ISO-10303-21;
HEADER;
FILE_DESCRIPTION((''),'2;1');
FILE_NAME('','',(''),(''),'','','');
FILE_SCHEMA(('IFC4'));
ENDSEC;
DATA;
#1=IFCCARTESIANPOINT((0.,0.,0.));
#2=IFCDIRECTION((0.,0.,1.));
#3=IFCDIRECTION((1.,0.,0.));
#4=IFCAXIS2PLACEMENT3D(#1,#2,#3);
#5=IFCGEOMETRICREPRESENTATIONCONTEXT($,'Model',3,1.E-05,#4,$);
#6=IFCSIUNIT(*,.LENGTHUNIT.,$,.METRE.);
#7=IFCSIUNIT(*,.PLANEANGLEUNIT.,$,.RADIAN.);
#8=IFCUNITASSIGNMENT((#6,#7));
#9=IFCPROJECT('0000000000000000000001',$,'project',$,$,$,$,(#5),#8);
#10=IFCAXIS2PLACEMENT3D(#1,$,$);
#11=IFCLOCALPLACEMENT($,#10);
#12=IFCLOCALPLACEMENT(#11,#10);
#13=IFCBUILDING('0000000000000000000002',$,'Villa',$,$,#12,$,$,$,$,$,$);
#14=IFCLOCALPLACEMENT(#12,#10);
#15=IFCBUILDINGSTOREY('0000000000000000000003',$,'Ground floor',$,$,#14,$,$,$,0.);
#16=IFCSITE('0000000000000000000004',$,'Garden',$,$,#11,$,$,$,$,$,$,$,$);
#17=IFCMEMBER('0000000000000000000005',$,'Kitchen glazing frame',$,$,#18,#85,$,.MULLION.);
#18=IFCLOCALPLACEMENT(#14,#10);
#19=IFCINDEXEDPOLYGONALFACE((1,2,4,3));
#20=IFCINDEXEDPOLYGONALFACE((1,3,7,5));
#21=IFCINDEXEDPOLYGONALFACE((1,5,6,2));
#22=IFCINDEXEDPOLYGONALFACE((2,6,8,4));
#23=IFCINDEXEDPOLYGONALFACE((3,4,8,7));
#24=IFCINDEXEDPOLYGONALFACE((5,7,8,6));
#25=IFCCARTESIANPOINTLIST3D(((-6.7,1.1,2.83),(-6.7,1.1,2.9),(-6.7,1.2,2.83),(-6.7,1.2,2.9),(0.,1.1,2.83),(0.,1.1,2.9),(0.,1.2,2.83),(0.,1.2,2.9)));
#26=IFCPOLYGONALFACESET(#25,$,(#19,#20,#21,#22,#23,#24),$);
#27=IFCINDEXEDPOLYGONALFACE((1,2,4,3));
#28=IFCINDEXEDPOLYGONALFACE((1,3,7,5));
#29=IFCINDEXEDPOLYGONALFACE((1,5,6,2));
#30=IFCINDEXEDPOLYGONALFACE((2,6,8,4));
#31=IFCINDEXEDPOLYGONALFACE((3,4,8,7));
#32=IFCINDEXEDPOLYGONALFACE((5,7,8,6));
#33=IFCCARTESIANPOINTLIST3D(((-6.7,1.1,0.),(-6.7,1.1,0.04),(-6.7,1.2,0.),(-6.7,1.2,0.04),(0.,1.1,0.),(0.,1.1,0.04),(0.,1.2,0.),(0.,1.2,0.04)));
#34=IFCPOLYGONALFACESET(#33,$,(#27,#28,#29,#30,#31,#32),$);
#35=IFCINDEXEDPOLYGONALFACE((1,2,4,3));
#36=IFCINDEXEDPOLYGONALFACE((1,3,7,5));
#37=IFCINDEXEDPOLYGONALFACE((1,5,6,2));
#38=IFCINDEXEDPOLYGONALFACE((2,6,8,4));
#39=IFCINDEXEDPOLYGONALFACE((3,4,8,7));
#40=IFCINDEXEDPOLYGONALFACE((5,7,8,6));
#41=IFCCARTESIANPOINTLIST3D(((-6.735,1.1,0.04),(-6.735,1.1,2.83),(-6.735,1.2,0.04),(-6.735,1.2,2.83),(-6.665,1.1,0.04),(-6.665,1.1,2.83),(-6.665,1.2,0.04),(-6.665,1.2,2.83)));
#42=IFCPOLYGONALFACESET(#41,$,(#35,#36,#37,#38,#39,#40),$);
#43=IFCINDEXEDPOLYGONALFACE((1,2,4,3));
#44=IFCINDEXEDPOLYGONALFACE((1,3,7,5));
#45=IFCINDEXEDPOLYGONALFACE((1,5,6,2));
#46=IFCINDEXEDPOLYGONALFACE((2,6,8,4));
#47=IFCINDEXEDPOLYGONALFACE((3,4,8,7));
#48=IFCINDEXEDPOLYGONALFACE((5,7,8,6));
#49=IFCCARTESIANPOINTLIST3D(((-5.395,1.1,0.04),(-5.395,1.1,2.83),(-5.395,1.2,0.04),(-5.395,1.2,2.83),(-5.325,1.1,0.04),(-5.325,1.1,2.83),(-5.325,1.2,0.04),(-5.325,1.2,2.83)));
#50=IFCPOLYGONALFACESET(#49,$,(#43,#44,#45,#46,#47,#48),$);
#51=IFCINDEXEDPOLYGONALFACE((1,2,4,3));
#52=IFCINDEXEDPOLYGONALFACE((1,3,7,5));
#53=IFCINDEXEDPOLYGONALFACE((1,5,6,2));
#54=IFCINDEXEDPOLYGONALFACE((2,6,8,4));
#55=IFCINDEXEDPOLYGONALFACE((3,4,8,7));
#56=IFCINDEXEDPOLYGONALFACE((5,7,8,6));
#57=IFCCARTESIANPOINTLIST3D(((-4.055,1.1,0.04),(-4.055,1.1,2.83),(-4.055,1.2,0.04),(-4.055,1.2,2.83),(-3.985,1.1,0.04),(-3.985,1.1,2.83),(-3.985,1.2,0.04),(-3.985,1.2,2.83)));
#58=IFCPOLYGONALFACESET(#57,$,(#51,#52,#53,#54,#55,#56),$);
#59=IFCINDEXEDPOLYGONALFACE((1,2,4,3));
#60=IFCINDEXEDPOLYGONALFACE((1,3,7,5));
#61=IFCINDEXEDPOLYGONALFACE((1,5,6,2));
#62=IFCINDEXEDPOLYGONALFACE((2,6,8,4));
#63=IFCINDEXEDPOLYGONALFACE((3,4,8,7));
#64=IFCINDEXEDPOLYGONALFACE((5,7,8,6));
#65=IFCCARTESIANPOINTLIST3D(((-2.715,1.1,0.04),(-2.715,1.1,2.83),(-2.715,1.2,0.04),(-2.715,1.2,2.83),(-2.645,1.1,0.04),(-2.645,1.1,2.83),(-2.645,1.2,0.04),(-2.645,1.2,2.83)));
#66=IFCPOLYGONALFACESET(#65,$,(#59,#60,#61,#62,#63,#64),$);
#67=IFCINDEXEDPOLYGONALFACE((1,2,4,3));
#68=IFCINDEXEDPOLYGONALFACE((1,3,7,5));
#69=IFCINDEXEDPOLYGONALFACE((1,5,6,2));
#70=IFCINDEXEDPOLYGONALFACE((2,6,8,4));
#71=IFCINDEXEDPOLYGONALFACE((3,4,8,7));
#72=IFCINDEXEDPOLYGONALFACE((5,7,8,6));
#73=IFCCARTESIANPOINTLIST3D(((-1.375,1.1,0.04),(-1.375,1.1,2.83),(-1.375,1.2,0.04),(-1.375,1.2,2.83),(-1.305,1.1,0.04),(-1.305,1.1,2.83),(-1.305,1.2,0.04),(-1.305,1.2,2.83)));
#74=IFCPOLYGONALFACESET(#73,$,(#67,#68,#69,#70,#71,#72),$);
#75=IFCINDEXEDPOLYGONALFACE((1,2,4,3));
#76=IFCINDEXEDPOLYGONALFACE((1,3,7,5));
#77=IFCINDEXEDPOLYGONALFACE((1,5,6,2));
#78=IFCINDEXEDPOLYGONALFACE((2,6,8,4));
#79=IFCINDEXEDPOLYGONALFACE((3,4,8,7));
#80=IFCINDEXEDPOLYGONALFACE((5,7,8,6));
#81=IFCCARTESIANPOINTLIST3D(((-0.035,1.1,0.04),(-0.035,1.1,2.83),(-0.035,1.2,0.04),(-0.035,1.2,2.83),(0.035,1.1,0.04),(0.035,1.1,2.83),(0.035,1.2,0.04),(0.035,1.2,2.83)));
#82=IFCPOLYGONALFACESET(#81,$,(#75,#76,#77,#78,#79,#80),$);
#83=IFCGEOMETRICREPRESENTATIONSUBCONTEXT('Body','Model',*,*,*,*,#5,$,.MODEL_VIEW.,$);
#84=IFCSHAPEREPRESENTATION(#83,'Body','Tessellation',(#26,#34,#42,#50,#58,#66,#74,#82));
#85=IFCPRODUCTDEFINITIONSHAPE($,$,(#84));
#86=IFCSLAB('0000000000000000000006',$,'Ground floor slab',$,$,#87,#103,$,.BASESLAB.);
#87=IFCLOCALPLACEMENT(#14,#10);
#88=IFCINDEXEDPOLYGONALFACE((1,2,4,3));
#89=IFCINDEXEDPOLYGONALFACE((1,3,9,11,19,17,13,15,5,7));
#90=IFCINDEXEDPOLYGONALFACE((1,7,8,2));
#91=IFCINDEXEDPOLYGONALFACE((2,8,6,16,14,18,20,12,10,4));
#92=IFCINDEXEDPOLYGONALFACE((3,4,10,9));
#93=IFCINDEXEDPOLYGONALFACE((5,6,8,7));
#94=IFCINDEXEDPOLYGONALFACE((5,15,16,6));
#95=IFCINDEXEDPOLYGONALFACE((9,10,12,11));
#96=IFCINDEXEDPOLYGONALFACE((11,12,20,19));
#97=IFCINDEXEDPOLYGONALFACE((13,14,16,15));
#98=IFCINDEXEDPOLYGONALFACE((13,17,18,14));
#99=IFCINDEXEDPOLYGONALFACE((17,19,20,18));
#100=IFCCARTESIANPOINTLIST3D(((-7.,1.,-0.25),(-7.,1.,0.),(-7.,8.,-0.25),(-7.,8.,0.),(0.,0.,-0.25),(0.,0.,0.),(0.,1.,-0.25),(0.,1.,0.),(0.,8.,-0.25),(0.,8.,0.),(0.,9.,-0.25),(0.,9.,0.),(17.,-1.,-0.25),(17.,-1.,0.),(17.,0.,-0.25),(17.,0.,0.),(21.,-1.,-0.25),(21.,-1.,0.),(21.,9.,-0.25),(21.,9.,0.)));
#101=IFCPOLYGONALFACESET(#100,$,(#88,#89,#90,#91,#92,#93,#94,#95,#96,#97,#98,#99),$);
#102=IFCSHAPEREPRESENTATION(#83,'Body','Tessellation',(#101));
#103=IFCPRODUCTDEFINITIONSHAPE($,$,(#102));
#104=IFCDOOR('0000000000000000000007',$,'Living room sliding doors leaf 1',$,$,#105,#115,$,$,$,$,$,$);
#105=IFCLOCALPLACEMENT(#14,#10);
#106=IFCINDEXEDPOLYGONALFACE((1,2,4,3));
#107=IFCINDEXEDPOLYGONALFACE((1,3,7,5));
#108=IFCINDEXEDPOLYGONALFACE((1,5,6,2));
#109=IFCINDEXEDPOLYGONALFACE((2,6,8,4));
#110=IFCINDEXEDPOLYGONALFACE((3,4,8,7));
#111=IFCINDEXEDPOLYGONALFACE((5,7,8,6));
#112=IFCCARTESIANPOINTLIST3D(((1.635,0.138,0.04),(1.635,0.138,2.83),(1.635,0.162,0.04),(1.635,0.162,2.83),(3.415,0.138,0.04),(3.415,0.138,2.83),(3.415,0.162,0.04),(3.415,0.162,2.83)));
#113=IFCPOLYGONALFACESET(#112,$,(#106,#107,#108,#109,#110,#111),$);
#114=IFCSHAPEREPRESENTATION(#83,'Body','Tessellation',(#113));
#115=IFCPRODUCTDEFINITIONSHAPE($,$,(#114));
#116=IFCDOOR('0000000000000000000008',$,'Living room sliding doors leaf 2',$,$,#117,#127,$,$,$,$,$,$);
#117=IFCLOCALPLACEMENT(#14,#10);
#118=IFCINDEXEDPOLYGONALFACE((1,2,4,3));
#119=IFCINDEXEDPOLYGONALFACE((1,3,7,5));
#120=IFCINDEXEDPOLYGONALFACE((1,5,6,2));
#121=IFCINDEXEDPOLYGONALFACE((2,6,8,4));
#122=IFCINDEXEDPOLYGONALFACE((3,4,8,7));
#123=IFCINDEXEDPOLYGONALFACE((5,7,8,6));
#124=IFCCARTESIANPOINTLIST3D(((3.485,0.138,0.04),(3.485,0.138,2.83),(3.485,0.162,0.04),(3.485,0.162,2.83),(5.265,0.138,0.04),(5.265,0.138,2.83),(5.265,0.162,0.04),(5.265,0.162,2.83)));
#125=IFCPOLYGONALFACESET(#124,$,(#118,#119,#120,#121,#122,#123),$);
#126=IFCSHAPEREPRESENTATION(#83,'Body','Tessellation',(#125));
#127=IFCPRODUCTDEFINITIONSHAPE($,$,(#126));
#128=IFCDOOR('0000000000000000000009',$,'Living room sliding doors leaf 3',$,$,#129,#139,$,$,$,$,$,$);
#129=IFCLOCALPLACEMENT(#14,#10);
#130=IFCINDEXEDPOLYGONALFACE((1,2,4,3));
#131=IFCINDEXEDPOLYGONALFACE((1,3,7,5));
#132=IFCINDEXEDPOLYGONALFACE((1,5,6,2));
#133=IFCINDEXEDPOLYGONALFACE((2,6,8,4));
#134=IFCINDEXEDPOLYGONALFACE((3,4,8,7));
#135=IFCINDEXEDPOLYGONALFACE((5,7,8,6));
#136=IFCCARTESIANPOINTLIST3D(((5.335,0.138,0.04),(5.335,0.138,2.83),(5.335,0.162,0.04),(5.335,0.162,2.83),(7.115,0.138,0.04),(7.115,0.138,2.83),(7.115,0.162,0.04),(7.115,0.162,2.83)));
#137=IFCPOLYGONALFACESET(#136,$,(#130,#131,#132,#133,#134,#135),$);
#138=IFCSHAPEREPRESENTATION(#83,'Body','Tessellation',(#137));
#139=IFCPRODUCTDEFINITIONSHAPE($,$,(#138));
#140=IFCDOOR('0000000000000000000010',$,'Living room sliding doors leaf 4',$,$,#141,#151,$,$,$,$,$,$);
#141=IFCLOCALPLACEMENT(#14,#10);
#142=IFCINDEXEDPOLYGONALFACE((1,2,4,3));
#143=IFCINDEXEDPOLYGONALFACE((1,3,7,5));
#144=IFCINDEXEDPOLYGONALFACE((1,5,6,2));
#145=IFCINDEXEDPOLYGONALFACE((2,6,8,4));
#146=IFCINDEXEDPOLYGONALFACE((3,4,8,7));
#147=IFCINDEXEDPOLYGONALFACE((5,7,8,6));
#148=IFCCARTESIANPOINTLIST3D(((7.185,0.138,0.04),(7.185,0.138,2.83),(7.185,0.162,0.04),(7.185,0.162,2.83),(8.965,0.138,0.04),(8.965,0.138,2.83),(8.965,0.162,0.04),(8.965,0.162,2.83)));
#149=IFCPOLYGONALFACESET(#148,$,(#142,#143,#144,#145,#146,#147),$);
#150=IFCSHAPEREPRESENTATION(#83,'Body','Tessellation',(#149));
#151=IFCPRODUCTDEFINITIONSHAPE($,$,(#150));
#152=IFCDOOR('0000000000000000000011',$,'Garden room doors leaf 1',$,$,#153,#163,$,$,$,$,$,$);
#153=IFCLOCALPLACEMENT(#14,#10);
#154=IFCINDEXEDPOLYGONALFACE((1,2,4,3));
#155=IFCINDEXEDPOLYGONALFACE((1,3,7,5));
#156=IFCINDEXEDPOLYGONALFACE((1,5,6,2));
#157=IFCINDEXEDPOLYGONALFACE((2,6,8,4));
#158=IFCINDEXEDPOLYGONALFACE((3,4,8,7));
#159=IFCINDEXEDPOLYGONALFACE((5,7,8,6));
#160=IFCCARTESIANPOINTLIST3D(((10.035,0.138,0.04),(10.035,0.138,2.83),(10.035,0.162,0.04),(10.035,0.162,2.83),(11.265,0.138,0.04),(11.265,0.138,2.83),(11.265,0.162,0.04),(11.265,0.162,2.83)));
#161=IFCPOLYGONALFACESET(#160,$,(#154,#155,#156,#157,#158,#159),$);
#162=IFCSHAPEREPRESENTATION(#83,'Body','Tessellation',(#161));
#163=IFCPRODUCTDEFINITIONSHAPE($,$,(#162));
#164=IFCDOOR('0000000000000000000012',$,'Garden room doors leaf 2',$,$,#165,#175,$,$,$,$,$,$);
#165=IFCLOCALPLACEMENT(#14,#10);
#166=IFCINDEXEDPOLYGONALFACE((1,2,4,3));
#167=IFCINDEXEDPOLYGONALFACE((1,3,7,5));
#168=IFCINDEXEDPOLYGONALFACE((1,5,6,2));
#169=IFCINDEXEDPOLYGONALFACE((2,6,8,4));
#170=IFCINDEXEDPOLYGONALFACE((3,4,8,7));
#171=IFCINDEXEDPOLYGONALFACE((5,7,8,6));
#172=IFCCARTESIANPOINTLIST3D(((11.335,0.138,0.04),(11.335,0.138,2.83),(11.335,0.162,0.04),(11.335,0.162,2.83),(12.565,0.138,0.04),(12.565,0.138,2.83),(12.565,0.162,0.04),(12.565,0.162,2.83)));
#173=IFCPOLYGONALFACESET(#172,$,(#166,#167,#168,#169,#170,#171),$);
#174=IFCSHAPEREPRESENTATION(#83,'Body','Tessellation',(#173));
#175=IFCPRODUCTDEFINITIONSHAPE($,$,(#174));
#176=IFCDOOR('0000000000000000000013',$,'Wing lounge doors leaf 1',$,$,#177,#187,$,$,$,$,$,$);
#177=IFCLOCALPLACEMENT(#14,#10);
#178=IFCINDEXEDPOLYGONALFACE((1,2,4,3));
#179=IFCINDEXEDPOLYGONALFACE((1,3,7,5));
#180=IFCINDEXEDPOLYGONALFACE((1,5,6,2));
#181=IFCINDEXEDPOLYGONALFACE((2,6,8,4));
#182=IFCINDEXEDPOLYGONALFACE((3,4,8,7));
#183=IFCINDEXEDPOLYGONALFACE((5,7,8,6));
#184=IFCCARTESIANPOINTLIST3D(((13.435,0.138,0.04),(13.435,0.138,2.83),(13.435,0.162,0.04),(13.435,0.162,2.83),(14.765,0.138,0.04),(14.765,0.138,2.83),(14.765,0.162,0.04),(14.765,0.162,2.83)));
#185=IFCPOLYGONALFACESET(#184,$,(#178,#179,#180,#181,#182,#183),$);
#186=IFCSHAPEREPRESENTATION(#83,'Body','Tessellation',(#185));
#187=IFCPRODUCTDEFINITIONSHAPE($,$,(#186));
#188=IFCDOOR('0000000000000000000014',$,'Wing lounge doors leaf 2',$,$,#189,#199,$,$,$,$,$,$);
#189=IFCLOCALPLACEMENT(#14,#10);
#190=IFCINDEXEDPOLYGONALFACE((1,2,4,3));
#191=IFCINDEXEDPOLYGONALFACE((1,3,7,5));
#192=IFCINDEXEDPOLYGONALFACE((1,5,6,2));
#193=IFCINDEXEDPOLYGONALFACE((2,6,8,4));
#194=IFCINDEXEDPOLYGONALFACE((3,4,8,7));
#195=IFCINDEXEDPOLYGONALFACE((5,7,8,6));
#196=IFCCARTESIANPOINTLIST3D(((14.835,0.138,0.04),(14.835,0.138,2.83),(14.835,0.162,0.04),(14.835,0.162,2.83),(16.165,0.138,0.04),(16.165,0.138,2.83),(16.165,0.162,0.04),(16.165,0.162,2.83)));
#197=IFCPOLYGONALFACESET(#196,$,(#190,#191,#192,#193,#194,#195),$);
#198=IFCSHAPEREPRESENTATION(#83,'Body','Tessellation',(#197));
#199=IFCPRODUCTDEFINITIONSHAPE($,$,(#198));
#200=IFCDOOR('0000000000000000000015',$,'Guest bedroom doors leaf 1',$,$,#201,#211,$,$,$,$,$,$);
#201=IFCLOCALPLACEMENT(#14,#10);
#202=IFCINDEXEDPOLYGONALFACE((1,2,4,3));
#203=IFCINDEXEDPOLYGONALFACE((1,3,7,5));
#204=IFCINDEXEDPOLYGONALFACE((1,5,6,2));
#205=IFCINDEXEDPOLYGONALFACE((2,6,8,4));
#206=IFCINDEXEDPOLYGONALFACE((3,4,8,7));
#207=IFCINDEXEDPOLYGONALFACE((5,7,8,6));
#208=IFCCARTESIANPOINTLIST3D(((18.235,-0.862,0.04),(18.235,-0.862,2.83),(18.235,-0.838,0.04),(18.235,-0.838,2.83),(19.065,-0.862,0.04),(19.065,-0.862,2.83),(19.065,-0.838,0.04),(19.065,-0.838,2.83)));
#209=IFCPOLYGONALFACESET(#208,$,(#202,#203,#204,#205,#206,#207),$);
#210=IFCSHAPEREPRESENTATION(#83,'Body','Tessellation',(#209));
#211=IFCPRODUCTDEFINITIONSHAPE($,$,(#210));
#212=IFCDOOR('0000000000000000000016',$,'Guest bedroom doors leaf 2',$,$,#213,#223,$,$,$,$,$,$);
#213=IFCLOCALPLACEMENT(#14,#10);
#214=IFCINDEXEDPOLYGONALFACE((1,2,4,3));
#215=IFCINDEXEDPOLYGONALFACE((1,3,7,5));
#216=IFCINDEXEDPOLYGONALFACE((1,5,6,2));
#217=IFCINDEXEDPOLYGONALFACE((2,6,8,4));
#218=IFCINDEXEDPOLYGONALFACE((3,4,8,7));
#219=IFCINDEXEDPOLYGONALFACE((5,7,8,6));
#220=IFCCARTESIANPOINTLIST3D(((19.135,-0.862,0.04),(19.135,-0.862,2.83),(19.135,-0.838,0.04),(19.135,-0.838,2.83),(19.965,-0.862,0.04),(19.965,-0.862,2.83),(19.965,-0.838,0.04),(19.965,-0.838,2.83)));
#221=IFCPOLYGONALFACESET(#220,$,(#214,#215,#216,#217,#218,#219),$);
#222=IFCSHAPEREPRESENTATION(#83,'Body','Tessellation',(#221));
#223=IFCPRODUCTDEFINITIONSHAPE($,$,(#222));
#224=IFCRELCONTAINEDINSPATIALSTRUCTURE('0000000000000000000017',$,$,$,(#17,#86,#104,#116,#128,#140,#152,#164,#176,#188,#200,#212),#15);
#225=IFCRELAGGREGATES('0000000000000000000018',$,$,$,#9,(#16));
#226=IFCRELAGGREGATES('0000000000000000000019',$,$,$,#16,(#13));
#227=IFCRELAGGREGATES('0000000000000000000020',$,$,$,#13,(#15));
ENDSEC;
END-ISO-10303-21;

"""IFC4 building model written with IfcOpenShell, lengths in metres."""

from ifc_helpers import new_model, si_unit, frame, frame_2d, origin, origin_with_axes, place, context, subcontext, project, spatial, polyline, rectangle, outline, extrude, element, save


model = new_model("IFC4")

# Units and contexts
model_context = context("Model", 3, precision=1e-05, world=origin_with_axes())
body_context = subcontext(model_context, "Body", "Model", "MODEL_VIEW")
ifc_project = project(units=[si_unit("LENGTHUNIT", "METRE"), si_unit("PLANEANGLEUNIT", "RADIAN")], contexts=[model_context])

# Site, building, storey
site_placement = place(None, origin())
site = spatial("IfcSite", under=ifc_project, at=site_placement, Name="Garden")
building_placement = place(site_placement, origin())
building = spatial("IfcBuilding", under=site, at=building_placement, Name="Villa")
storey_placement = place(building_placement, origin())
storey = spatial("IfcBuildingStorey", under=building, at=storey_placement, Name="Ground floor", Elevation=0.0)

# Member
member_1_placement = place(storey_placement, origin())
element("IfcMember", 1, at=member_1_placement, inside=storey, Name="Kitchen glazing frame", PredefinedType="MULLION", context=body_context, shape_type="SweptSolid", body=[
    extrude(rectangle(XDim=6.7, YDim=0.1, at=frame_2d((3.35, 0.05))), frame((-6.7, 1.1, 2.83)), (0.0, 0.0, 1.0), 0.07),
    extrude(rectangle(XDim=6.7, YDim=0.1, at=frame_2d((3.35, 0.05))), frame((-6.7, 1.1, 0.0)), (0.0, 0.0, 1.0), 0.04),
    extrude(rectangle(XDim=0.07, YDim=0.1, at=frame_2d((0.035, 0.05))), frame((-6.735, 1.1, 0.04)), (0.0, 0.0, 1.0), 2.79),
    extrude(rectangle(XDim=0.07, YDim=0.1, at=frame_2d((0.035, 0.05))), frame((-5.395, 1.1, 0.04)), (0.0, 0.0, 1.0), 2.79),
    extrude(rectangle(XDim=0.07, YDim=0.1, at=frame_2d((0.035, 0.05))), frame((-4.055, 1.1, 0.04)), (0.0, 0.0, 1.0), 2.79),
    extrude(rectangle(XDim=0.07, YDim=0.1, at=frame_2d((0.035, 0.05))), frame((-2.715, 1.1, 0.04)), (0.0, 0.0, 1.0), 2.79),
    extrude(rectangle(XDim=0.07, YDim=0.1, at=frame_2d((0.035, 0.05))), frame((-1.375, 1.1, 0.04)), (0.0, 0.0, 1.0), 2.79),
    extrude(rectangle(XDim=0.07, YDim=0.1, at=frame_2d((0.035, 0.05))), frame((-0.035, 1.1, 0.04)), (0.0, 0.0, 1.0), 2.79),
])

# Slab
slab_placement = place(storey_placement, frame((0.0, 0.0, -0.25)))
element("IfcSlab", 2, at=slab_placement, inside=storey, Name="Ground floor slab", PredefinedType="BASESLAB", context=body_context, shape_type="SweptSolid", body=[
    extrude(outline(polyline([(0.0, 0.0), (17.0, 0.0), (17.0, -1.0), (21.0, -1.0), (21.0, 9.0), (0.0, 9.0), (0.0, 8.0), (-7.0, 8.0), (-7.0, 1.0), (0.0, 1.0), (0.0, 0.0)])), origin(), (0.0, 0.0, 1.0), 0.25),
])

# Doors
door_1_placement = place(storey_placement, origin())
element("IfcDoor", 3, at=door_1_placement, inside=storey, Name="Living room sliding doors leaf 1", context=body_context, shape_type="SweptSolid", body=[
    extrude(rectangle(XDim=1.78, YDim=0.024, at=frame_2d((0.89, 0.012))), frame((1.635, 0.138, 0.04)), (0.0, 0.0, 1.0), 2.79),
])
door_2_placement = place(storey_placement, origin())
element("IfcDoor", 4, at=door_2_placement, inside=storey, Name="Living room sliding doors leaf 2", context=body_context, shape_type="SweptSolid", body=[
    extrude(rectangle(XDim=1.78, YDim=0.024, at=frame_2d((0.89, 0.012))), frame((3.485, 0.138, 0.04)), (0.0, 0.0, 1.0), 2.79),
])
door_3_placement = place(storey_placement, origin())
element("IfcDoor", 5, at=door_3_placement, inside=storey, Name="Living room sliding doors leaf 3", context=body_context, shape_type="SweptSolid", body=[
    extrude(rectangle(XDim=1.78, YDim=0.024, at=frame_2d((0.89, 0.012))), frame((5.335, 0.138, 0.04)), (0.0, 0.0, 1.0), 2.79),
])
door_4_placement = place(storey_placement, origin())
element("IfcDoor", 6, at=door_4_placement, inside=storey, Name="Living room sliding doors leaf 4", context=body_context, shape_type="SweptSolid", body=[
    extrude(rectangle(XDim=1.78, YDim=0.024, at=frame_2d((0.89, 0.012))), frame((7.185, 0.138, 0.04)), (0.0, 0.0, 1.0), 2.79),
])
door_5_placement = place(storey_placement, origin())
element("IfcDoor", 7, at=door_5_placement, inside=storey, Name="Garden room doors leaf 1", context=body_context, shape_type="SweptSolid", body=[
    extrude(rectangle(XDim=1.23, YDim=0.024, at=frame_2d((0.615, 0.012))), frame((10.035, 0.138, 0.04)), (0.0, 0.0, 1.0), 2.79),
])
door_6_placement = place(storey_placement, origin())
element("IfcDoor", 8, at=door_6_placement, inside=storey, Name="Garden room doors leaf 2", context=body_context, shape_type="SweptSolid", body=[
    extrude(rectangle(XDim=1.23, YDim=0.024, at=frame_2d((0.615, 0.012))), frame((11.335, 0.138, 0.04)), (0.0, 0.0, 1.0), 2.79),
])
door_7_placement = place(storey_placement, origin())
element("IfcDoor", 9, at=door_7_placement, inside=storey, Name="Wing lounge doors leaf 1", context=body_context, shape_type="SweptSolid", body=[
    extrude(rectangle(XDim=1.33, YDim=0.024, at=frame_2d((0.665, 0.012))), frame((13.435, 0.138, 0.04)), (0.0, 0.0, 1.0), 2.79),
])
door_8_placement = place(storey_placement, origin())
element("IfcDoor", 10, at=door_8_placement, inside=storey, Name="Wing lounge doors leaf 2", context=body_context, shape_type="SweptSolid", body=[
    extrude(rectangle(XDim=1.33, YDim=0.024, at=frame_2d((0.665, 0.012))), frame((14.835, 0.138, 0.04)), (0.0, 0.0, 1.0), 2.79),
])
door_9_placement = place(storey_placement, origin())
element("IfcDoor", 11, at=door_9_placement, inside=storey, Name="Guest bedroom doors leaf 1", context=body_context, shape_type="SweptSolid", body=[
    extrude(rectangle(XDim=0.83, YDim=0.024, at=frame_2d((0.415, 0.012))), frame((18.235, -0.862, 0.04)), (0.0, 0.0, 1.0), 2.79),
])
door_10_placement = place(storey_placement, origin())
element("IfcDoor", 12, at=door_10_placement, inside=storey, Name="Guest bedroom doors leaf 2", context=body_context, shape_type="SweptSolid", body=[
    extrude(rectangle(XDim=0.83, YDim=0.024, at=frame_2d((0.415, 0.012))), frame((19.135, -0.862, 0.04)), (0.0, 0.0, 1.0), 2.79),
])

save(model, "model.ifc")
